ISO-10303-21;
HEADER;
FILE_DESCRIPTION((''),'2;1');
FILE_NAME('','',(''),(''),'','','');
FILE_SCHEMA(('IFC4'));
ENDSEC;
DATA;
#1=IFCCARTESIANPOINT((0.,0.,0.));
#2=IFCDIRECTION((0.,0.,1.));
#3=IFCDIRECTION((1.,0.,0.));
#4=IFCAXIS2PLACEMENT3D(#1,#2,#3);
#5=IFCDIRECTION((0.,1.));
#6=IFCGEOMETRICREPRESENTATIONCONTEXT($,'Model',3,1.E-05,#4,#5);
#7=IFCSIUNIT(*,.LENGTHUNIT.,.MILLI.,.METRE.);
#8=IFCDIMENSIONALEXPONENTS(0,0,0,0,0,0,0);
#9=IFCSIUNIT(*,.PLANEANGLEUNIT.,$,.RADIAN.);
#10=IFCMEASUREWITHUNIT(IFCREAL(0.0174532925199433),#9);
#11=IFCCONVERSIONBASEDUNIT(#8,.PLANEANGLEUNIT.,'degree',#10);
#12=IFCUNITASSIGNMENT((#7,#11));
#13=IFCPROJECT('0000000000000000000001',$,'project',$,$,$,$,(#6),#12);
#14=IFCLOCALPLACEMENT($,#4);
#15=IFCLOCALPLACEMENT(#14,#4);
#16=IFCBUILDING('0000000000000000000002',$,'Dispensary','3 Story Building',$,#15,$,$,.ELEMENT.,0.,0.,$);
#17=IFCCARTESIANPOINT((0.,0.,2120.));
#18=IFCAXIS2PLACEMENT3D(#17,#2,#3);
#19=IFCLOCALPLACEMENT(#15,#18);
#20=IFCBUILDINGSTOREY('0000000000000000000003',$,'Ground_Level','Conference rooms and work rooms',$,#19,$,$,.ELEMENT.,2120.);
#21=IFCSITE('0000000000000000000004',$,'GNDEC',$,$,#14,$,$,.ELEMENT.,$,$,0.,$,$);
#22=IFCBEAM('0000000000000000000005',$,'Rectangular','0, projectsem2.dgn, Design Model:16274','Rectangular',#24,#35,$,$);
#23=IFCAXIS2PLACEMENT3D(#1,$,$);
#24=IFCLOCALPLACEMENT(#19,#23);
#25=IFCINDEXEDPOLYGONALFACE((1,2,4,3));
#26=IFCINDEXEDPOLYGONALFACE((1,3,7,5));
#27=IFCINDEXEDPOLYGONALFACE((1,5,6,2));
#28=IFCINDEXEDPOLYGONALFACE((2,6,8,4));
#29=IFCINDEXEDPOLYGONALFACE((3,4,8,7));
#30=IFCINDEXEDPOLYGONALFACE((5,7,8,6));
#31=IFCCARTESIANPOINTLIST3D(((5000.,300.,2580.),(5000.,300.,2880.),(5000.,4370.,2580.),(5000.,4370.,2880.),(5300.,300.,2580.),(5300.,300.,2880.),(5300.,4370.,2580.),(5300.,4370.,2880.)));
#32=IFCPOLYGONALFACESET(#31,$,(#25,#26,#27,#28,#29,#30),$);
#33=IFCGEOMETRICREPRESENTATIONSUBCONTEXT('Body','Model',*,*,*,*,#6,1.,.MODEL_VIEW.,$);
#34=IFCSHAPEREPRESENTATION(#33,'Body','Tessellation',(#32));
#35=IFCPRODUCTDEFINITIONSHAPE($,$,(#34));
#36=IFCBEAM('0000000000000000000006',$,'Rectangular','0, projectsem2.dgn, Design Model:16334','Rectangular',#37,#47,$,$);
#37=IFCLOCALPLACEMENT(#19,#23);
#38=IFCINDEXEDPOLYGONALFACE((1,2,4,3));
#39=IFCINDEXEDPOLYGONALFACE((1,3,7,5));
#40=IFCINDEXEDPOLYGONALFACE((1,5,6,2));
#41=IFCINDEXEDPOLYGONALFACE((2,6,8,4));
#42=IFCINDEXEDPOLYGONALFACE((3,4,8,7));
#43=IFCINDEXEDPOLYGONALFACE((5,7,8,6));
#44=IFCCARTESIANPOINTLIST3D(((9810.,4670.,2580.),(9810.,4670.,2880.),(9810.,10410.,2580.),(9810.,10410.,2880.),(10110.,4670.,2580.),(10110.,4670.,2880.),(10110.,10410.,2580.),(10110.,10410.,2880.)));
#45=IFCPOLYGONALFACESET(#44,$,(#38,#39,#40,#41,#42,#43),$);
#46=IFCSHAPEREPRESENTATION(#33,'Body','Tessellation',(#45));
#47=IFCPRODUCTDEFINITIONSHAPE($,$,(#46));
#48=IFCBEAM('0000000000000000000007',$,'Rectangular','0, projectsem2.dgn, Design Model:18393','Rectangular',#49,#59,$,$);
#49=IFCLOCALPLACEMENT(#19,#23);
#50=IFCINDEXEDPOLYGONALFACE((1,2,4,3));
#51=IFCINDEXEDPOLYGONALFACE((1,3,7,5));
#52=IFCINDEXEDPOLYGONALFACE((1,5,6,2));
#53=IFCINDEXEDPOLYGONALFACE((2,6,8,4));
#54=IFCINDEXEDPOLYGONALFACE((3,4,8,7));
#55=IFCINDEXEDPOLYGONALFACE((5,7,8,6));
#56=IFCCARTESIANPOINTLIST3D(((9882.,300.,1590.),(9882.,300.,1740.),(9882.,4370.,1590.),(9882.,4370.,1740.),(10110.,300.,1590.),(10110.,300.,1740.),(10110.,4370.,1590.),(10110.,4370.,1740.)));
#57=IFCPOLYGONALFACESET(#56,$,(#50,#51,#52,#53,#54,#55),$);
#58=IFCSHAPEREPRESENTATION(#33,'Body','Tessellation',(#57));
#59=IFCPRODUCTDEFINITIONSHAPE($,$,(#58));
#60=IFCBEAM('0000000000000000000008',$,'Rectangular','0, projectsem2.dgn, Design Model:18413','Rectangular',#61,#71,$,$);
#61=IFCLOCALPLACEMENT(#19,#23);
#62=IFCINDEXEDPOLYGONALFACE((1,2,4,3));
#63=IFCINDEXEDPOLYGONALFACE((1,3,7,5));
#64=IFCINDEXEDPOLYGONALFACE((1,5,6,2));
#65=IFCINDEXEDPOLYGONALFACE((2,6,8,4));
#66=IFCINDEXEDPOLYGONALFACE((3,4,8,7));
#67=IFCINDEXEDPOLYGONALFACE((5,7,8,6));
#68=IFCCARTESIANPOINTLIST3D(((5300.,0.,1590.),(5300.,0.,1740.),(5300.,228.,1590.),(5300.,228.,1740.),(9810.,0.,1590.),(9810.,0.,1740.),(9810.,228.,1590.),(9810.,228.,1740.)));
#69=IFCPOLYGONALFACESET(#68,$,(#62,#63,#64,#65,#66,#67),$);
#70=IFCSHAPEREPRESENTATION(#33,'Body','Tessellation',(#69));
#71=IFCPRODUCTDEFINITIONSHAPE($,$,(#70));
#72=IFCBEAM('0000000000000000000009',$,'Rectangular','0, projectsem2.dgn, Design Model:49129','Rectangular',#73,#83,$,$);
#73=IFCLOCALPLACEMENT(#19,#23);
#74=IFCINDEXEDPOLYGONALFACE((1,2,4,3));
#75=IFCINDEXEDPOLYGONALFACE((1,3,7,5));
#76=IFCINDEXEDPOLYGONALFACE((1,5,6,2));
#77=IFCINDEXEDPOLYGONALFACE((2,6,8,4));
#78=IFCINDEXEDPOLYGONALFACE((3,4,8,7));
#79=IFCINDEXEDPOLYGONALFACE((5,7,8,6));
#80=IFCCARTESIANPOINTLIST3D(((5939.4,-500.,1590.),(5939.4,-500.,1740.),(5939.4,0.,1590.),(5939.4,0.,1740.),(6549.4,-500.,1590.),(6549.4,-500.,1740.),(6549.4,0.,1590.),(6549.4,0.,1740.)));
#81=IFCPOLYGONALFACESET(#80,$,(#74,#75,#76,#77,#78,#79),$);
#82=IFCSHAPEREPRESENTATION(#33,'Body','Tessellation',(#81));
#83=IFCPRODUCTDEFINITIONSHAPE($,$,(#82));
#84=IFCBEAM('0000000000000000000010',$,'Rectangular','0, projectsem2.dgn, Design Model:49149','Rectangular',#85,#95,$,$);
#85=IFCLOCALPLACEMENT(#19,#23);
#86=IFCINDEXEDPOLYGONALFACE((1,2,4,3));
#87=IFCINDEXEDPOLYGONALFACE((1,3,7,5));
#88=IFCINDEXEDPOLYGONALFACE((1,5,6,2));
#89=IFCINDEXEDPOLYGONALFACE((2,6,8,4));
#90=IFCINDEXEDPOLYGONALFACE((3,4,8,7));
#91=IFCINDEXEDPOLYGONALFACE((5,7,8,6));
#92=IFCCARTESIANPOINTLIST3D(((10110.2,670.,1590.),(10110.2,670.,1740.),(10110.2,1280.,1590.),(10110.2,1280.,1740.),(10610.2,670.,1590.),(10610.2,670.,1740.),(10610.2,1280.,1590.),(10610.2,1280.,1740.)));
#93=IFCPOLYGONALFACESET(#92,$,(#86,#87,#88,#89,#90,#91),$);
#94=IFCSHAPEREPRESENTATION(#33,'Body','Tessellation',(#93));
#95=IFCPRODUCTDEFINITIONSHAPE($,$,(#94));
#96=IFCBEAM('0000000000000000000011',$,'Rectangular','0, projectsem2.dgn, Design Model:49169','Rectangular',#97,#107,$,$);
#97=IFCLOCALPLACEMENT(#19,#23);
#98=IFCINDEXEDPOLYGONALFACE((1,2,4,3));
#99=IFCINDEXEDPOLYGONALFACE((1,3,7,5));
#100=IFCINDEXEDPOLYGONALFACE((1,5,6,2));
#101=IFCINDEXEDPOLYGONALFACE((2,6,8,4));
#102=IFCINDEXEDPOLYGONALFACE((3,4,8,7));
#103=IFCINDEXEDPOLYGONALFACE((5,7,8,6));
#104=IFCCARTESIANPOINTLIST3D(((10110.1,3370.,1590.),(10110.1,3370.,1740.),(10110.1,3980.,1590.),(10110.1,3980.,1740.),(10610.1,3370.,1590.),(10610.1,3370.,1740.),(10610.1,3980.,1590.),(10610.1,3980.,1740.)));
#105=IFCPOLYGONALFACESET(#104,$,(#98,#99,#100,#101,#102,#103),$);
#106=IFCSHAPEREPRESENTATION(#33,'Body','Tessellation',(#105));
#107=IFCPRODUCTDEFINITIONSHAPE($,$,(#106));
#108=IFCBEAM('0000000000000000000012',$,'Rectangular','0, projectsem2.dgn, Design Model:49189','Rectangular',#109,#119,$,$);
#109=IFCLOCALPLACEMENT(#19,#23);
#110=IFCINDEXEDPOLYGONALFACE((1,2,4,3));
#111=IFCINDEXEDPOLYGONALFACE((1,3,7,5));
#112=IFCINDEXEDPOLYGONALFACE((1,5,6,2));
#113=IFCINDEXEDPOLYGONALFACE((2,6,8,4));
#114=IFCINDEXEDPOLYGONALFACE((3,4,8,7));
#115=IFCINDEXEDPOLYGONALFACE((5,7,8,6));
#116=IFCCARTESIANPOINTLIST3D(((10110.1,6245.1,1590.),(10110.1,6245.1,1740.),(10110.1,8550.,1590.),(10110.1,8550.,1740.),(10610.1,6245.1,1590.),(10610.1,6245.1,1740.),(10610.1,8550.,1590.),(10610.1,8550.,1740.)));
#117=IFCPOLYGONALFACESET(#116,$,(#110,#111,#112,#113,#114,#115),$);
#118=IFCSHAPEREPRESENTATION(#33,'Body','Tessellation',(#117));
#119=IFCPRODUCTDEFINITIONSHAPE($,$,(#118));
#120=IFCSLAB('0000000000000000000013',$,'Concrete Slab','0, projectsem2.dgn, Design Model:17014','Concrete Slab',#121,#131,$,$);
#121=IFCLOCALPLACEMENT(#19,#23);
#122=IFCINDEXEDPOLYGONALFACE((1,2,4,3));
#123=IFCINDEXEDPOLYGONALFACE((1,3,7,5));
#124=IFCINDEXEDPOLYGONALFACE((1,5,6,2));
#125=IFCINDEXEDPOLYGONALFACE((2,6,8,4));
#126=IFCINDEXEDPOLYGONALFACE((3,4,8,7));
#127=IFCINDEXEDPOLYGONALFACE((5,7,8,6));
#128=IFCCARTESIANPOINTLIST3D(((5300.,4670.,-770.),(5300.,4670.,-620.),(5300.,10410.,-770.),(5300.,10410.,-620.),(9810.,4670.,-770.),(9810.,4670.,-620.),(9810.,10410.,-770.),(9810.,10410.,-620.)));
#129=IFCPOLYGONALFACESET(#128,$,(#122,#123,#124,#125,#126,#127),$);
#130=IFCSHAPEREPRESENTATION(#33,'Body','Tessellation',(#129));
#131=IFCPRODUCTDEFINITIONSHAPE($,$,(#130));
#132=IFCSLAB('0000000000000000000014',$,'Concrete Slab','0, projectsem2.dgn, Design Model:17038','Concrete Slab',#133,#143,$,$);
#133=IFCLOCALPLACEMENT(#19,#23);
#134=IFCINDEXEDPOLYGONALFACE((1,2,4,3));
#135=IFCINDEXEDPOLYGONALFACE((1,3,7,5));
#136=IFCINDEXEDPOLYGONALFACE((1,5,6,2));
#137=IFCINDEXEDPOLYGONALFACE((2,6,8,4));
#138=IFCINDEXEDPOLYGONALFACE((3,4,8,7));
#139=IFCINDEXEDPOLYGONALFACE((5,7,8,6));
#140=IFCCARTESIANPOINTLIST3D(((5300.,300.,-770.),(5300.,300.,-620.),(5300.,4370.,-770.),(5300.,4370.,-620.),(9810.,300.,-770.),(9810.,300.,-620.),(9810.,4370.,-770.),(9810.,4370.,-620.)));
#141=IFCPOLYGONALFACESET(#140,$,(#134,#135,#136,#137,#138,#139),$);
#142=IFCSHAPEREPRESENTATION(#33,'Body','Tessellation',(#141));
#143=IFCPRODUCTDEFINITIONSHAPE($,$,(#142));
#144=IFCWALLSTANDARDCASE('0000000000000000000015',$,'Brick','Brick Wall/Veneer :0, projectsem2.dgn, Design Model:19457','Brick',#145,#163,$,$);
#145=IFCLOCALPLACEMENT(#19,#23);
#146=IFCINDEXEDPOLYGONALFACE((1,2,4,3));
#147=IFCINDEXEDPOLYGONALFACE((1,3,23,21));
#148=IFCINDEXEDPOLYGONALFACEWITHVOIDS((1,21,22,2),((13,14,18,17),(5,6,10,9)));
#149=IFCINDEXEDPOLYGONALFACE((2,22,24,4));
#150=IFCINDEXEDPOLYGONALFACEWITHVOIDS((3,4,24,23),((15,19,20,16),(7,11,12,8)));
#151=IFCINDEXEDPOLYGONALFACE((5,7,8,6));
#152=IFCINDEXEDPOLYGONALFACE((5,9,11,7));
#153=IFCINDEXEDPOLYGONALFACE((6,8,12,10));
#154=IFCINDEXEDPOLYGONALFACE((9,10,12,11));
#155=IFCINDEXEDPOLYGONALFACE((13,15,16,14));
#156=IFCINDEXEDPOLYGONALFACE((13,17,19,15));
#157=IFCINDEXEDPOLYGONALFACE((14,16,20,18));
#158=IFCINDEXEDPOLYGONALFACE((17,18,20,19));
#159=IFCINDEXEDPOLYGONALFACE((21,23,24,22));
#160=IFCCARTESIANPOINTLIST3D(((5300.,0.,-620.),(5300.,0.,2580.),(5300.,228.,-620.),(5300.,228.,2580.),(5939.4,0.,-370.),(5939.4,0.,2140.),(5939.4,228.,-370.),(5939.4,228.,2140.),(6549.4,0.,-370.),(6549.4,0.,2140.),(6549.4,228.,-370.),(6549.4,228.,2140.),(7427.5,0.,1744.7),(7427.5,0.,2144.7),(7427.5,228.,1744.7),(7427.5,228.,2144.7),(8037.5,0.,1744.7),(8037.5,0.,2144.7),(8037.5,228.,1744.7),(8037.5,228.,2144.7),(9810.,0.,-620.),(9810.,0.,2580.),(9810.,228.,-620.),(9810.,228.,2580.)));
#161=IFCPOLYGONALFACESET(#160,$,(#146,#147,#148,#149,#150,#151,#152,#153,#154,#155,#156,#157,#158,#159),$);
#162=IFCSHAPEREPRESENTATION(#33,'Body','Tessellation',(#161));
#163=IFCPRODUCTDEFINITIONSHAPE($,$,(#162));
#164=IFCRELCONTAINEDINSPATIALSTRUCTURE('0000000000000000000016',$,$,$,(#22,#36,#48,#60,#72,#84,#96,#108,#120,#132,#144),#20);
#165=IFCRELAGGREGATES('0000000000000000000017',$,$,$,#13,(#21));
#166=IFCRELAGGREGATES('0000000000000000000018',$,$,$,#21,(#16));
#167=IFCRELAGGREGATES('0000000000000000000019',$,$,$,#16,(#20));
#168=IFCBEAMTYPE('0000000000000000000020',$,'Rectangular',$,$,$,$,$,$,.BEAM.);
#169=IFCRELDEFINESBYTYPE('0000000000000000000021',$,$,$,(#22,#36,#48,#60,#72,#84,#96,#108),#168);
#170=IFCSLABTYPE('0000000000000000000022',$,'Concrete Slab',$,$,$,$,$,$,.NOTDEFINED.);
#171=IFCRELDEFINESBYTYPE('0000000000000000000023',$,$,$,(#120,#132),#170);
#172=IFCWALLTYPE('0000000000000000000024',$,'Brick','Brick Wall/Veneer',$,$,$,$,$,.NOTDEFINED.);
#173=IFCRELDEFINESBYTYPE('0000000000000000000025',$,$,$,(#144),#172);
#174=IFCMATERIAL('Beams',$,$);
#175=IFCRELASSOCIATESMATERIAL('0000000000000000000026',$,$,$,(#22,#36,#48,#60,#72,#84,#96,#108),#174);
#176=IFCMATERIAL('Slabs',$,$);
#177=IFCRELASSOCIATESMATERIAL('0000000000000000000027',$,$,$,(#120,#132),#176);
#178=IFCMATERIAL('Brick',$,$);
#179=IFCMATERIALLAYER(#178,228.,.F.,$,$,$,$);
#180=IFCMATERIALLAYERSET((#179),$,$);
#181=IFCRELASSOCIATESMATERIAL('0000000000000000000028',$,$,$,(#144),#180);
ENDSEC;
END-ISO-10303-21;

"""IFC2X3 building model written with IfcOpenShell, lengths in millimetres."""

from ifc_helpers import new_model, entity, si_unit, converted_unit, direction, frame, frame_2d, origin_with_axes, place, context, subcontext, project, spatial, rectangle, extrude, material, layer, layer_set, layer_usage, type_object, element, save


model = new_model("IFC2X3")

# Units and contexts
model_context = context("Model", 3, precision=1e-05, world=origin_with_axes(), true_north=direction((0.0, 1.0)))
body_context = subcontext(model_context, "Body", "Model", "MODEL_VIEW", scale=1.0)
ifc_project = project(units=[si_unit("LENGTHUNIT", "METRE", prefix="MILLI"), converted_unit("PLANEANGLEUNIT", "degree", entity("IfcReal", 0.0174532925199433), si_unit("PLANEANGLEUNIT", "RADIAN"), dimensions=[0, 0, 0, 0, 0, 0, 0])], contexts=[model_context])

# Site, building, storey
site_placement = place(None, origin_with_axes())
site = spatial("IfcSite", under=ifc_project, at=site_placement, Name="GNDEC", CompositionType="ELEMENT", RefElevation=0.0)
building_placement = place(site_placement, origin_with_axes())
building = spatial("IfcBuilding", under=site, at=building_placement, Name="Dispensary", Description="3 Story Building", CompositionType="ELEMENT", ElevationOfRefHeight=0.0, ElevationOfTerrain=0.0)
storey_placement = place(building_placement, frame((0.0, 0.0, 2120.0), z_axis=(0.0, 0.0, 1.0), x_axis=(1.0, 0.0, 0.0)))
storey = spatial("IfcBuildingStorey", under=building, at=storey_placement, Name="Ground_Level", Description="Conference rooms and work rooms", CompositionType="ELEMENT", Elevation=2120.0)

# Beams
ifc_material_1 = material(Name="Beams")
beam_type = type_object("IfcBeamType", Name="Rectangular", PredefinedType="BEAM")
beam_1_placement = place(storey_placement, frame((5000.0, 300.0, 2580.0), z_axis=(0.0, 1.0, 0.0), x_axis=(0.0, 0.0, 1.0)))
element("IfcBeam", 1, at=beam_1_placement, inside=storey, type_object=beam_type, material=ifc_material_1, Name="Rectangular", Description="0, projectsem2.dgn, Design Model:16274", ObjectType="Rectangular", context=body_context, shape_type="SweptSolid", body=[
    extrude(rectangle(XDim=300.0, YDim=300.0, at=frame_2d((150.0, 150.0), x_axis=(0.0, 1.0))), origin_with_axes(), (0.0, 0.0, 1.0), 4070.0),
])
beam_2_placement = place(storey_placement, frame((9810.0, 4670.0, 2580.0), z_axis=(0.0, 1.0, 0.0), x_axis=(0.0, 0.0, 1.0)))
element("IfcBeam", 2, at=beam_2_placement, inside=storey, type_object=beam_type, material=ifc_material_1, Name="Rectangular", Description="0, projectsem2.dgn, Design Model:16334", ObjectType="Rectangular", context=body_context, shape_type="SweptSolid", body=[
    extrude(rectangle(XDim=300.0, YDim=300.0, at=frame_2d((150.0, 150.0), x_axis=(0.0, 1.0))), origin_with_axes(), (0.0, 0.0, 1.0), 5740.0),
])
beam_3_placement = place(storey_placement, frame((9882.0, 4370.0, 1590.0), z_axis=(0.0, -1.0, 0.0), x_axis=(1.0, 0.0, 0.0)))
element("IfcBeam", 3, at=beam_3_placement, inside=storey, type_object=beam_type, material=ifc_material_1, Name="Rectangular", Description="0, projectsem2.dgn, Design Model:18393", ObjectType="Rectangular", context=body_context, shape_type="SweptSolid", body=[
    extrude(rectangle(XDim=150.0, YDim=228.0, at=frame_2d((114.0, 75.0), x_axis=(0.0, 1.0))), origin_with_axes(), (0.0, 0.0, 1.0), 4070.0),
])
beam_4_placement = place(storey_placement, frame((9810.0, 228.0, 1590.0), z_axis=(-1.0, 0.0, 0.0), x_axis=(0.0, -1.0, 0.0)))
element("IfcBeam", 4, at=beam_4_placement, inside=storey, type_object=beam_type, material=ifc_material_1, Name="Rectangular", Description="0, projectsem2.dgn, Design Model:18413", ObjectType="Rectangular", context=body_context, shape_type="SweptSolid", body=[
    extrude(rectangle(XDim=150.0, YDim=228.0, at=frame_2d((114.0, 75.0), x_axis=(0.0, 1.0))), origin_with_axes(), (0.0, 0.0, 1.0), 4510.0),
])
for number, where, z_axis, x_axis, name, description in (
    (5, (5939.4, -500.0, 1590.0), (1.0, 0.0, 0.0), (0.0, 1.0, 0.0), "Rectangular", "0, projectsem2.dgn, Design Model:49129"),
    (6, (10610.2, 670.0, 1590.0), (-0.000011, 1.0, 0.0), (-1.0, -0.000011, 0.0), "Rectangular", "0, projectsem2.dgn, Design Model:49149"),
    (7, (10610.1, 3370.0, 1590.0), (-0.000011, 1.0, 0.0), (-1.0, -0.000011, 0.0), "Rectangular", "0, projectsem2.dgn, Design Model:49169"),
):
    element("IfcBeam", number, at=place(storey_placement, frame(where, z_axis=z_axis, x_axis=x_axis)), inside=storey, type_object=beam_type, material=ifc_material_1, Name=name, Description=description, ObjectType="Rectangular", context=body_context, shape_type="SweptSolid", body=[
        extrude(rectangle(XDim=150.0, YDim=500.0, at=frame_2d((250.0, 75.0), x_axis=(0.0, 1.0))), origin_with_axes(), (0.0, 0.0, 1.0), 610.0),
    ])
beam_5_placement = place(storey_placement, frame((10610.1, 6245.1, 1590.0), z_axis=(-0.000011, 1.0, 0.0), x_axis=(-1.0, -0.000011, 0.0)))
element("IfcBeam", 8, at=beam_5_placement, inside=storey, type_object=beam_type, material=ifc_material_1, Name="Rectangular", Description="0, projectsem2.dgn, Design Model:49189", ObjectType="Rectangular", context=body_context, shape_type="SweptSolid", body=[
    extrude(rectangle(XDim=150.0, YDim=500.0, at=frame_2d((250.0, 75.0), x_axis=(0.0, 1.0))), origin_with_axes(), (0.0, 0.0, 1.0), 2304.9),
])

# Slabs
ifc_material_2 = material(Name="Slabs")
slab_type = type_object("IfcSlabType", Name="Concrete Slab", PredefinedType="NOTDEFINED")
for number, where, z_axis, x_axis, name in (
    (9, (5300.0, 4670.0, -620.0), (0.0, 0.0, -1.0), (1.0, 0.0, 0.0), "Concrete Slab"),
):
    element("IfcSlab", number, at=place(storey_placement, frame(where, z_axis=z_axis, x_axis=x_axis)), inside=storey, type_object=slab_type, material=ifc_material_2, Name=name, Description="0, projectsem2.dgn, Design Model:17014", ObjectType="Concrete Slab", context=body_context, shape_type="SweptSolid", body=[
        extrude(rectangle(XDim=4510.0, YDim=5740.0, at=frame_2d((2255.0, -2870.0), x_axis=(1.0, 0.0))), origin_with_axes(), (0.0, 0.0, 1.0), 150.0),
    ])
for number, where, z_axis, x_axis, name in (
    (10, (9810.0, 300.0, -620.0), (0.0, 0.0, -1.0), (-1.0, 0.0, 0.0), "Concrete Slab"),
):
    element("IfcSlab", number, at=place(storey_placement, frame(where, z_axis=z_axis, x_axis=x_axis)), inside=storey, type_object=slab_type, material=ifc_material_2, Name=name, Description="0, projectsem2.dgn, Design Model:17038", ObjectType="Concrete Slab", context=body_context, shape_type="SweptSolid", body=[
        extrude(rectangle(XDim=4510.0, YDim=4070.0, at=frame_2d((2255.0, 2035.0), x_axis=(1.0, 0.0))), origin_with_axes(), (0.0, 0.0, 1.0), 150.0),
    ])

# Wall, openings
ifc_material_3 = material(Name="Brick")
ifc_layer = layer(ifc_material_3, 228.0, ventilated=False)
ifc_layer_set = layer_set([ifc_layer])
ifc_layer_usage = layer_usage(ifc_layer_set, "AXIS2", "POSITIVE", 0.0)
wall_type = type_object("IfcWallType", Name="Brick", Description="Brick Wall/Veneer", PredefinedType="NOTDEFINED")
wall_1_placement = place(storey_placement, frame((5300.0, 228.0, -620.0), z_axis=(0.0, 0.0, 1.0), x_axis=(1.0, 0.0, 0.0)))
wall_1 = element("IfcWallStandardCase", 11, at=wall_1_placement, inside=storey, type_object=wall_type, material=ifc_layer_usage, Name="Brick", Description="Brick Wall/Veneer :0, projectsem2.dgn, Design Model:19457", ObjectType="Brick", context=body_context, shape_type="SweptSolid", body=[
    extrude(rectangle(XDim=4510.0, YDim=228.0, at=frame_2d((2255.0, -114.0), x_axis=(-1.0, 0.0))), origin_with_axes(), (0.0, 0.0, 1.0), 3200.0),
])
opening_1_placement = place(wall_1_placement, frame((639.4, -228.0, 250.0), z_axis=(0.0, 0.0, 1.0), x_axis=(1.0, 0.0, 0.0)))
element("IfcOpeningElement", 12, at=opening_1_placement, cuts=wall_1, ObjectType="Opening", context=body_context, shape_type="SweptSolid", body=[
    extrude(rectangle(XDim=2510.0, YDim=610.0, at=frame_2d((-305.0, 1255.0), x_axis=(0.0, -1.0))), frame((0.0, 0.0, 0.0), z_axis=(0.0, 1.0, 0.0), x_axis=(-1.0, 0.0, 0.0)), (0.0, 0.0, 1.0), 228.0),
])
opening_2_placement = place(wall_1_placement, frame((2127.5, -228.0, 2364.7), z_axis=(0.0, 0.0, 1.0), x_axis=(1.0, 0.0, 0.0)))
element("IfcOpeningElement", 13, at=opening_2_placement, cuts=wall_1, ObjectType="Opening", context=body_context, shape_type="SweptSolid", body=[
    extrude(rectangle(XDim=610.0, YDim=400.0, at=frame_2d((-305.0, 200.0), x_axis=(-1.0, 0.0))), frame((0.0, 0.0, 0.0), z_axis=(0.0, 1.0, 0.0), x_axis=(-1.0, 0.0, 0.0)), (0.0, 0.0, 1.0), 228.0),
])

save(model, "model.ifc")
